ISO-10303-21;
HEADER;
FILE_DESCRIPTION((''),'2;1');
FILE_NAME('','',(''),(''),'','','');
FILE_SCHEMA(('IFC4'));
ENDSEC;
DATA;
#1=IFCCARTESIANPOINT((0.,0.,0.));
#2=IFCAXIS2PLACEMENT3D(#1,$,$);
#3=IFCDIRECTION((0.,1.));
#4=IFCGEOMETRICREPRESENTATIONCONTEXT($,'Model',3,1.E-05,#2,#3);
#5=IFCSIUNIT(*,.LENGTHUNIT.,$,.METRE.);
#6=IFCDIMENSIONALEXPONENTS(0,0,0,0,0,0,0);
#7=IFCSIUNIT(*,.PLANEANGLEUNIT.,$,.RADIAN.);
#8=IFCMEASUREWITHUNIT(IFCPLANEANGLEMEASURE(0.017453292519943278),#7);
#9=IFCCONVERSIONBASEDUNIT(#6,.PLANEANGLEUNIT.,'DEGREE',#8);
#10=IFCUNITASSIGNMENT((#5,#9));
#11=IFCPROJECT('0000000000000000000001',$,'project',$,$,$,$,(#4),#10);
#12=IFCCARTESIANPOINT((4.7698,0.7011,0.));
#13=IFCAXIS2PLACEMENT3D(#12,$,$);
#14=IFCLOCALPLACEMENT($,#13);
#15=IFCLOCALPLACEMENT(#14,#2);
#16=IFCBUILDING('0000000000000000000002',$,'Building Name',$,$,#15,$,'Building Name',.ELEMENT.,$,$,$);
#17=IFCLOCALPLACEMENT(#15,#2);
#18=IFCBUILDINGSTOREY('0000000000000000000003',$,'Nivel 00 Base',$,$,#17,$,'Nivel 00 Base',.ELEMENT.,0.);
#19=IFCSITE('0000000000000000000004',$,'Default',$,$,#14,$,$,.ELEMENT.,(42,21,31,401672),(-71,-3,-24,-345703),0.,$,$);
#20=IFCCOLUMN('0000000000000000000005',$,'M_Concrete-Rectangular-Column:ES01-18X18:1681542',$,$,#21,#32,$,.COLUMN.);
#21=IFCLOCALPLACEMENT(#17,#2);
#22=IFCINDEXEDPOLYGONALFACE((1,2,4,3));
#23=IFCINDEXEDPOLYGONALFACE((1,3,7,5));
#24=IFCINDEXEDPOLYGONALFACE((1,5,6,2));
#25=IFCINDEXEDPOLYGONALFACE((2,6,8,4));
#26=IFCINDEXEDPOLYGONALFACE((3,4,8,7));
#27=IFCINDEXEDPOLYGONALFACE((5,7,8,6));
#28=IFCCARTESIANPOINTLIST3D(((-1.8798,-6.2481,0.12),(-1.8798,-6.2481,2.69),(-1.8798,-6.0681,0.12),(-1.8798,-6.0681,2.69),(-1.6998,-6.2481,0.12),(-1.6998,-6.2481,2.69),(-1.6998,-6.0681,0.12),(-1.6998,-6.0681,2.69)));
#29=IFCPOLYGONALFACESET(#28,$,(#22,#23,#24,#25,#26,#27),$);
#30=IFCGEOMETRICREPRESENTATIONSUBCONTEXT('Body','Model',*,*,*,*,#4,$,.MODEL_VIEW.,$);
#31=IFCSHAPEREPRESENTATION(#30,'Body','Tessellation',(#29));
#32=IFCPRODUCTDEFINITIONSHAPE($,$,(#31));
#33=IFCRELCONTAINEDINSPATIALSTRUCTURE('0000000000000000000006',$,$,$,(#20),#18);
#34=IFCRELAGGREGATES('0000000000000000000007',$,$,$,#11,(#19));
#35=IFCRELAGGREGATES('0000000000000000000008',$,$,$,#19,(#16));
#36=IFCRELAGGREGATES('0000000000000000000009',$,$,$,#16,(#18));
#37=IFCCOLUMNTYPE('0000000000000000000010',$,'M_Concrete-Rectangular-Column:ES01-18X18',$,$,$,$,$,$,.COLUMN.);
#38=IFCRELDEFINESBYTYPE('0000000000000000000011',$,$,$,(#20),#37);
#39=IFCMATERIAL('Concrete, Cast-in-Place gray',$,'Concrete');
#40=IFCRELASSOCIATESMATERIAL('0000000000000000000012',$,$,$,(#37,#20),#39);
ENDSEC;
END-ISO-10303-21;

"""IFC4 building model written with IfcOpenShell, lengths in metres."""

from ifc_helpers import new_model, entity, si_unit, converted_unit, direction, frame, origin, place, context, subcontext, project, spatial, indexed_curve, outline, extrude, source, transform, mapped, material, type_object, type_shapes, element, save


model = new_model("IFC4")

# Units and contexts
model_context = context("Model", 3, precision=1e-05, world=origin(), true_north=direction((0.0, 1.0)))
body_context = subcontext(model_context, "Body", "Model", "MODEL_VIEW")
ifc_project = project(units=[si_unit("LENGTHUNIT", "METRE"), converted_unit("PLANEANGLEUNIT", "DEGREE", entity("IfcPlaneAngleMeasure", 0.017453292519943278), si_unit("PLANEANGLEUNIT", "RADIAN"), dimensions=[0, 0, 0, 0, 0, 0, 0])], contexts=[model_context])

# Site, building, storey
site_placement = place(None, frame((4.7698, 0.7011, 0.0)))
site = spatial("IfcSite", under=ifc_project, at=site_placement, Name="Default", CompositionType="ELEMENT", RefLatitude=(42, 21, 31, 401672), RefLongitude=(-71, -3, -24, -345703), RefElevation=0.0)
building_placement = place(site_placement, origin())
building = spatial("IfcBuilding", under=site, at=building_placement, Name="Building Name", LongName="Building Name", CompositionType="ELEMENT")
storey_placement = place(building_placement, origin())
storey = spatial("IfcBuildingStorey", under=building, at=storey_placement, Name="Nivel 00 Base", LongName="Nivel 00 Base", CompositionType="ELEMENT", Elevation=0.0)

# Column
ifc_material_1 = material(Name="Concrete, Cast-in-Place gray", Category="Concrete")
column_type_1 = type_object("IfcColumnType", Name="M_Concrete-Rectangular-Column:ES01-18X18", PredefinedType="COLUMN", material=ifc_material_1)
shared_shape_1 = source(origin(), body_context, "Body", "SweptSolid", [
    extrude(outline(indexed_curve([(-0.09, -0.09), (0.09, -0.09), (0.09, 0.09), (-0.09, 0.09), (-0.09, -0.09)], self_intersect=False)), frame((-1.7898, -6.1581, 0.12), z_axis=(0.0, 0.0, 1.0), x_axis=(-1.0, 0.0, 0.0)), (0.0, 0.0, 1.0), 2.57),
])
type_shapes(column_type_1, [shared_shape_1])
column_1_placement = place(storey_placement, origin())
element("IfcColumn", 1, at=column_1_placement, inside=storey, type_object=column_type_1, material=ifc_material_1, Name="M_Concrete-Rectangular-Column:ES01-18X18:1681542", PredefinedType="COLUMN", context=body_context, shape_type="MappedRepresentation", body=[
    mapped(shared_shape_1, transform((0.0, 0.0, 0.0), scale=1.0)),
])

save(model, "model.ifc")
